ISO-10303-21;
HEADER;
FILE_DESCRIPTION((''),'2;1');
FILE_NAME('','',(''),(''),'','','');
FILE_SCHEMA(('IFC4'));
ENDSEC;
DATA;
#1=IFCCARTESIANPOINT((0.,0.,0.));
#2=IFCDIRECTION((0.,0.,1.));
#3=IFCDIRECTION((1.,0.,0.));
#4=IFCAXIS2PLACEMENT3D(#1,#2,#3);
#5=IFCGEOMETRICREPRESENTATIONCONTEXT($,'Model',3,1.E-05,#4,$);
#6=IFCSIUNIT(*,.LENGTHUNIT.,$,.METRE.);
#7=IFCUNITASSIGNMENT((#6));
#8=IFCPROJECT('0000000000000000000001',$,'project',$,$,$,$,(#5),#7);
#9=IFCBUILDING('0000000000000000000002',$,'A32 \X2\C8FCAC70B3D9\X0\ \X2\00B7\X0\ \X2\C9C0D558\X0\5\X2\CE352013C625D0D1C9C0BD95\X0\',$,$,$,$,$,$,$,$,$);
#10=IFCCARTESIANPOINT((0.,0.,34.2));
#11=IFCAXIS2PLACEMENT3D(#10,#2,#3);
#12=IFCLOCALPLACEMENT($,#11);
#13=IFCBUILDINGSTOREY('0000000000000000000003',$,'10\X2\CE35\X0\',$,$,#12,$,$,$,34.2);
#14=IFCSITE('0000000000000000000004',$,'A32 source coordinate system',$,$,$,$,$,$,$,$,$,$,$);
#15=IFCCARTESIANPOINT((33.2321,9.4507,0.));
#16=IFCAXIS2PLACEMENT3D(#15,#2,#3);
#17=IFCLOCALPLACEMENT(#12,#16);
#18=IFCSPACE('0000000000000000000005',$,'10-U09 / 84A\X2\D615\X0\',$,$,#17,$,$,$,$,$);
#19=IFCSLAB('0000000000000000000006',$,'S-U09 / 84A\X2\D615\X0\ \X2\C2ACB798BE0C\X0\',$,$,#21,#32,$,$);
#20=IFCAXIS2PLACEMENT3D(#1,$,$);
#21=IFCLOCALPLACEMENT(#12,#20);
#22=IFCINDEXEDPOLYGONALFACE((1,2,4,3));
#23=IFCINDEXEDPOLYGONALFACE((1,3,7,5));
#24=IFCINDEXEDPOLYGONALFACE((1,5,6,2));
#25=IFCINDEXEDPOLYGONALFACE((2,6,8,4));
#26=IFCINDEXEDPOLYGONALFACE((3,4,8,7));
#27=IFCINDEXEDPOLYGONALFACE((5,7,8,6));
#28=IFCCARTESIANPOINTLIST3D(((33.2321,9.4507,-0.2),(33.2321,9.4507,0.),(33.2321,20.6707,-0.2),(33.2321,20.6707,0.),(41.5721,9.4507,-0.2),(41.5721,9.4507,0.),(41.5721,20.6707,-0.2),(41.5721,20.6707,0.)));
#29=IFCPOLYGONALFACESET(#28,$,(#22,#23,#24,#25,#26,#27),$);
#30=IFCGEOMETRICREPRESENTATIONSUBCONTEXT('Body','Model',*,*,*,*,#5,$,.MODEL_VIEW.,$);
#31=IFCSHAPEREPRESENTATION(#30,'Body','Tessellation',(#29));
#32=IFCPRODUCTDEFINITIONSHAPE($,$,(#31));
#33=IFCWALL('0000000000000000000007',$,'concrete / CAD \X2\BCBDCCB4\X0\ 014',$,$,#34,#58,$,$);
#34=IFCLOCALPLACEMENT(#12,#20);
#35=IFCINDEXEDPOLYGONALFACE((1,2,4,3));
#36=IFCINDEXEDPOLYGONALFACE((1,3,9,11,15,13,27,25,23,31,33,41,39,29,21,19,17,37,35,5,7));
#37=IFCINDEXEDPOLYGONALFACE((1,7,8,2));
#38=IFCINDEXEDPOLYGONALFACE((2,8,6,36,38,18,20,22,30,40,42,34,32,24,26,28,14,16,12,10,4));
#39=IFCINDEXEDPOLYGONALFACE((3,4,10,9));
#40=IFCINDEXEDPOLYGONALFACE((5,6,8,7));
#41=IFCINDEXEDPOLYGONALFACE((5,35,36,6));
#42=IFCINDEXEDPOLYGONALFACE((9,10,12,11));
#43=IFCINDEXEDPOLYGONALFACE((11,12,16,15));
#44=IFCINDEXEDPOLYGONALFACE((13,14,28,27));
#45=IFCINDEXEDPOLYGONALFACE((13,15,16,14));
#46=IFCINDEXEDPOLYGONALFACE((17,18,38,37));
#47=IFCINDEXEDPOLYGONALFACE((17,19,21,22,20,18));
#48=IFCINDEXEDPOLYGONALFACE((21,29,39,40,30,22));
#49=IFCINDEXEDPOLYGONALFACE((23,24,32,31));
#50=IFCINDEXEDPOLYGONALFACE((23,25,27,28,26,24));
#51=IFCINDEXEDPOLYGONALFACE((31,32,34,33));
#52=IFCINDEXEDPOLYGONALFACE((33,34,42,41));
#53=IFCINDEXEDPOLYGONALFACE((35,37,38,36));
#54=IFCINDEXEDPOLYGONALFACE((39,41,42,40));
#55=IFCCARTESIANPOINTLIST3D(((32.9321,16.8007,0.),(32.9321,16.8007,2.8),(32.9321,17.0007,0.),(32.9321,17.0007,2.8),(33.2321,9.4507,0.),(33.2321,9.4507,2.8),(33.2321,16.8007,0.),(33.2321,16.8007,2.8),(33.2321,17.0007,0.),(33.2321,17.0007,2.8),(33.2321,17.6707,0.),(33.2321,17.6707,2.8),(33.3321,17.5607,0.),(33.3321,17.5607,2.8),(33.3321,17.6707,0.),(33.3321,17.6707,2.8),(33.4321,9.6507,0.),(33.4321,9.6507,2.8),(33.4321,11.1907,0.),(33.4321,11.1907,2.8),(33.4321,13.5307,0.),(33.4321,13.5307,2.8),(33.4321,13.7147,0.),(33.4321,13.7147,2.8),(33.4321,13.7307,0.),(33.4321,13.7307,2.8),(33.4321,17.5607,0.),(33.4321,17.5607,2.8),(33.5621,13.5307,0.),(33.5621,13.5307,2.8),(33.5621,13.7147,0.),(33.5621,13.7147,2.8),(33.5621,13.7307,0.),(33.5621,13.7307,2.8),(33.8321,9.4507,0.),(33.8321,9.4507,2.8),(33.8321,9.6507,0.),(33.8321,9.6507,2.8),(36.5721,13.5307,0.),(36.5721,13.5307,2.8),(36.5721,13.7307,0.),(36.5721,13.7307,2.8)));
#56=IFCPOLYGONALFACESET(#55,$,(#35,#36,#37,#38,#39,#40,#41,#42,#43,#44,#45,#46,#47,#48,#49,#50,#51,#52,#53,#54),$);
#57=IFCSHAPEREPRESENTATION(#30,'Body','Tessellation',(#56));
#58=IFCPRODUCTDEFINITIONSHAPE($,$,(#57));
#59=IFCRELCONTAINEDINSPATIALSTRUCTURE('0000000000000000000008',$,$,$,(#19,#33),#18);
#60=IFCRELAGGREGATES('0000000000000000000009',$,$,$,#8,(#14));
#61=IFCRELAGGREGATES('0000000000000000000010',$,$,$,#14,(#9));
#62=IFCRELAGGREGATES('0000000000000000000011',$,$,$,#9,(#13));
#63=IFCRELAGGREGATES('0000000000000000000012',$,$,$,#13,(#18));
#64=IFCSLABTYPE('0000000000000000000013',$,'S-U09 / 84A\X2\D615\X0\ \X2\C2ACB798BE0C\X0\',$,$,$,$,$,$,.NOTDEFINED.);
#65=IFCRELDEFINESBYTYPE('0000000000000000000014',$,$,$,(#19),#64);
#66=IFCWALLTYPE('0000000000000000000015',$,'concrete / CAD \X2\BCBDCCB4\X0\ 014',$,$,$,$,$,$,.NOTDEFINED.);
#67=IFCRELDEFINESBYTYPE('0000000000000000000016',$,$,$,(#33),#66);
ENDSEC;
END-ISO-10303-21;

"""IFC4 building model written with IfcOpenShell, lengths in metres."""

from ifc_helpers import new_model, si_unit, frame, origin, origin_with_axes, place, context, subcontext, project, spatial, polyline, outline, extrude, source, transform, mapped, type_object, type_shapes, element, save


model = new_model("IFC4")

# Units and contexts
model_context = context("Model", 3, precision=1e-05, world=origin_with_axes())
body_context = subcontext(model_context, "Body", "Model", "MODEL_VIEW")
ifc_project = project(units=[si_unit("LENGTHUNIT", "METRE")], contexts=[model_context])

# Site, building, storey, space
storey_placement = place(None, frame((0.0, 0.0, 34.2), z_axis=(0.0, 0.0, 1.0), x_axis=(1.0, 0.0, 0.0)))
space_placement = place(storey_placement, frame((33.2321, 9.4507, 0.0), z_axis=(0.0, 0.0, 1.0), x_axis=(1.0, 0.0, 0.0)))
site = spatial("IfcSite", under=ifc_project, Name="A32 source coordinate system")
building = spatial("IfcBuilding", under=site, Name="A32 주거동 · 지하5층–옥탑지붕")
storey = spatial("IfcBuildingStorey", under=building, at=storey_placement, Name="10층", Elevation=34.2)
space = spatial("IfcSpace", under=storey, at=space_placement, Name="10-U09 / 84A형")

# Slab
slab_type_1 = type_object("IfcSlabType", Name="S-U09 / 84A형 슬래브", PredefinedType="NOTDEFINED")
shared_shape_1 = source(origin(), body_context, "Body", "SweptSolid", [
    extrude(outline(polyline([(0.0, 11.22), (8.34, 11.22), (8.34, 0.0), (0.0, 0.0), (0.0, 11.22)])), frame((0.0, 0.0, -0.2)), (0.0, 0.0, 1.0), 0.2),
])
type_shapes(slab_type_1, [shared_shape_1])
slab_1_placement = place(space_placement, origin_with_axes())
element("IfcSlab", 1, at=slab_1_placement, inside=space, type_object=slab_type_1, Name="S-U09 / 84A형 슬래브", context=body_context, shape_type="MappedRepresentation", body=[
    mapped(shared_shape_1, transform((0.0, 0.0, 0.0), scale=1.0)),
])

# Wall
wall_type_1 = type_object("IfcWallType", Name="concrete / CAD 벽체 014", PredefinedType="NOTDEFINED")
shared_shape_2 = source(origin(), body_context, "Body", "SweptSolid", [
    extrude(outline(polyline([(3.34, 4.08), (0.33, 4.08), (0.2, 4.08), (0.2, 1.74), (0.2, 0.2), (0.6, 0.2), (0.6, 0.0), (0.0, 0.0), (0.0, 7.35), (-0.3, 7.35), (-0.3, 7.55), (0.0, 7.55), (0.0, 8.22), (0.1, 8.22), (0.1, 8.11), (0.2, 8.11), (0.2, 4.28), (0.2, 4.264), (0.33, 4.264), (0.33, 4.28), (3.34, 4.28), (3.34, 4.08)])), origin(), (0.0, 0.0, 1.0), 2.8),
])
type_shapes(wall_type_1, [shared_shape_2])
wall_1_placement = place(space_placement, origin_with_axes())
element("IfcWall", 2, at=wall_1_placement, inside=space, type_object=wall_type_1, Name="concrete / CAD 벽체 014", context=body_context, shape_type="MappedRepresentation", body=[
    mapped(shared_shape_2, transform((0.0, 0.0, 0.0), scale=1.0)),
])

save(model, "model.ifc")
